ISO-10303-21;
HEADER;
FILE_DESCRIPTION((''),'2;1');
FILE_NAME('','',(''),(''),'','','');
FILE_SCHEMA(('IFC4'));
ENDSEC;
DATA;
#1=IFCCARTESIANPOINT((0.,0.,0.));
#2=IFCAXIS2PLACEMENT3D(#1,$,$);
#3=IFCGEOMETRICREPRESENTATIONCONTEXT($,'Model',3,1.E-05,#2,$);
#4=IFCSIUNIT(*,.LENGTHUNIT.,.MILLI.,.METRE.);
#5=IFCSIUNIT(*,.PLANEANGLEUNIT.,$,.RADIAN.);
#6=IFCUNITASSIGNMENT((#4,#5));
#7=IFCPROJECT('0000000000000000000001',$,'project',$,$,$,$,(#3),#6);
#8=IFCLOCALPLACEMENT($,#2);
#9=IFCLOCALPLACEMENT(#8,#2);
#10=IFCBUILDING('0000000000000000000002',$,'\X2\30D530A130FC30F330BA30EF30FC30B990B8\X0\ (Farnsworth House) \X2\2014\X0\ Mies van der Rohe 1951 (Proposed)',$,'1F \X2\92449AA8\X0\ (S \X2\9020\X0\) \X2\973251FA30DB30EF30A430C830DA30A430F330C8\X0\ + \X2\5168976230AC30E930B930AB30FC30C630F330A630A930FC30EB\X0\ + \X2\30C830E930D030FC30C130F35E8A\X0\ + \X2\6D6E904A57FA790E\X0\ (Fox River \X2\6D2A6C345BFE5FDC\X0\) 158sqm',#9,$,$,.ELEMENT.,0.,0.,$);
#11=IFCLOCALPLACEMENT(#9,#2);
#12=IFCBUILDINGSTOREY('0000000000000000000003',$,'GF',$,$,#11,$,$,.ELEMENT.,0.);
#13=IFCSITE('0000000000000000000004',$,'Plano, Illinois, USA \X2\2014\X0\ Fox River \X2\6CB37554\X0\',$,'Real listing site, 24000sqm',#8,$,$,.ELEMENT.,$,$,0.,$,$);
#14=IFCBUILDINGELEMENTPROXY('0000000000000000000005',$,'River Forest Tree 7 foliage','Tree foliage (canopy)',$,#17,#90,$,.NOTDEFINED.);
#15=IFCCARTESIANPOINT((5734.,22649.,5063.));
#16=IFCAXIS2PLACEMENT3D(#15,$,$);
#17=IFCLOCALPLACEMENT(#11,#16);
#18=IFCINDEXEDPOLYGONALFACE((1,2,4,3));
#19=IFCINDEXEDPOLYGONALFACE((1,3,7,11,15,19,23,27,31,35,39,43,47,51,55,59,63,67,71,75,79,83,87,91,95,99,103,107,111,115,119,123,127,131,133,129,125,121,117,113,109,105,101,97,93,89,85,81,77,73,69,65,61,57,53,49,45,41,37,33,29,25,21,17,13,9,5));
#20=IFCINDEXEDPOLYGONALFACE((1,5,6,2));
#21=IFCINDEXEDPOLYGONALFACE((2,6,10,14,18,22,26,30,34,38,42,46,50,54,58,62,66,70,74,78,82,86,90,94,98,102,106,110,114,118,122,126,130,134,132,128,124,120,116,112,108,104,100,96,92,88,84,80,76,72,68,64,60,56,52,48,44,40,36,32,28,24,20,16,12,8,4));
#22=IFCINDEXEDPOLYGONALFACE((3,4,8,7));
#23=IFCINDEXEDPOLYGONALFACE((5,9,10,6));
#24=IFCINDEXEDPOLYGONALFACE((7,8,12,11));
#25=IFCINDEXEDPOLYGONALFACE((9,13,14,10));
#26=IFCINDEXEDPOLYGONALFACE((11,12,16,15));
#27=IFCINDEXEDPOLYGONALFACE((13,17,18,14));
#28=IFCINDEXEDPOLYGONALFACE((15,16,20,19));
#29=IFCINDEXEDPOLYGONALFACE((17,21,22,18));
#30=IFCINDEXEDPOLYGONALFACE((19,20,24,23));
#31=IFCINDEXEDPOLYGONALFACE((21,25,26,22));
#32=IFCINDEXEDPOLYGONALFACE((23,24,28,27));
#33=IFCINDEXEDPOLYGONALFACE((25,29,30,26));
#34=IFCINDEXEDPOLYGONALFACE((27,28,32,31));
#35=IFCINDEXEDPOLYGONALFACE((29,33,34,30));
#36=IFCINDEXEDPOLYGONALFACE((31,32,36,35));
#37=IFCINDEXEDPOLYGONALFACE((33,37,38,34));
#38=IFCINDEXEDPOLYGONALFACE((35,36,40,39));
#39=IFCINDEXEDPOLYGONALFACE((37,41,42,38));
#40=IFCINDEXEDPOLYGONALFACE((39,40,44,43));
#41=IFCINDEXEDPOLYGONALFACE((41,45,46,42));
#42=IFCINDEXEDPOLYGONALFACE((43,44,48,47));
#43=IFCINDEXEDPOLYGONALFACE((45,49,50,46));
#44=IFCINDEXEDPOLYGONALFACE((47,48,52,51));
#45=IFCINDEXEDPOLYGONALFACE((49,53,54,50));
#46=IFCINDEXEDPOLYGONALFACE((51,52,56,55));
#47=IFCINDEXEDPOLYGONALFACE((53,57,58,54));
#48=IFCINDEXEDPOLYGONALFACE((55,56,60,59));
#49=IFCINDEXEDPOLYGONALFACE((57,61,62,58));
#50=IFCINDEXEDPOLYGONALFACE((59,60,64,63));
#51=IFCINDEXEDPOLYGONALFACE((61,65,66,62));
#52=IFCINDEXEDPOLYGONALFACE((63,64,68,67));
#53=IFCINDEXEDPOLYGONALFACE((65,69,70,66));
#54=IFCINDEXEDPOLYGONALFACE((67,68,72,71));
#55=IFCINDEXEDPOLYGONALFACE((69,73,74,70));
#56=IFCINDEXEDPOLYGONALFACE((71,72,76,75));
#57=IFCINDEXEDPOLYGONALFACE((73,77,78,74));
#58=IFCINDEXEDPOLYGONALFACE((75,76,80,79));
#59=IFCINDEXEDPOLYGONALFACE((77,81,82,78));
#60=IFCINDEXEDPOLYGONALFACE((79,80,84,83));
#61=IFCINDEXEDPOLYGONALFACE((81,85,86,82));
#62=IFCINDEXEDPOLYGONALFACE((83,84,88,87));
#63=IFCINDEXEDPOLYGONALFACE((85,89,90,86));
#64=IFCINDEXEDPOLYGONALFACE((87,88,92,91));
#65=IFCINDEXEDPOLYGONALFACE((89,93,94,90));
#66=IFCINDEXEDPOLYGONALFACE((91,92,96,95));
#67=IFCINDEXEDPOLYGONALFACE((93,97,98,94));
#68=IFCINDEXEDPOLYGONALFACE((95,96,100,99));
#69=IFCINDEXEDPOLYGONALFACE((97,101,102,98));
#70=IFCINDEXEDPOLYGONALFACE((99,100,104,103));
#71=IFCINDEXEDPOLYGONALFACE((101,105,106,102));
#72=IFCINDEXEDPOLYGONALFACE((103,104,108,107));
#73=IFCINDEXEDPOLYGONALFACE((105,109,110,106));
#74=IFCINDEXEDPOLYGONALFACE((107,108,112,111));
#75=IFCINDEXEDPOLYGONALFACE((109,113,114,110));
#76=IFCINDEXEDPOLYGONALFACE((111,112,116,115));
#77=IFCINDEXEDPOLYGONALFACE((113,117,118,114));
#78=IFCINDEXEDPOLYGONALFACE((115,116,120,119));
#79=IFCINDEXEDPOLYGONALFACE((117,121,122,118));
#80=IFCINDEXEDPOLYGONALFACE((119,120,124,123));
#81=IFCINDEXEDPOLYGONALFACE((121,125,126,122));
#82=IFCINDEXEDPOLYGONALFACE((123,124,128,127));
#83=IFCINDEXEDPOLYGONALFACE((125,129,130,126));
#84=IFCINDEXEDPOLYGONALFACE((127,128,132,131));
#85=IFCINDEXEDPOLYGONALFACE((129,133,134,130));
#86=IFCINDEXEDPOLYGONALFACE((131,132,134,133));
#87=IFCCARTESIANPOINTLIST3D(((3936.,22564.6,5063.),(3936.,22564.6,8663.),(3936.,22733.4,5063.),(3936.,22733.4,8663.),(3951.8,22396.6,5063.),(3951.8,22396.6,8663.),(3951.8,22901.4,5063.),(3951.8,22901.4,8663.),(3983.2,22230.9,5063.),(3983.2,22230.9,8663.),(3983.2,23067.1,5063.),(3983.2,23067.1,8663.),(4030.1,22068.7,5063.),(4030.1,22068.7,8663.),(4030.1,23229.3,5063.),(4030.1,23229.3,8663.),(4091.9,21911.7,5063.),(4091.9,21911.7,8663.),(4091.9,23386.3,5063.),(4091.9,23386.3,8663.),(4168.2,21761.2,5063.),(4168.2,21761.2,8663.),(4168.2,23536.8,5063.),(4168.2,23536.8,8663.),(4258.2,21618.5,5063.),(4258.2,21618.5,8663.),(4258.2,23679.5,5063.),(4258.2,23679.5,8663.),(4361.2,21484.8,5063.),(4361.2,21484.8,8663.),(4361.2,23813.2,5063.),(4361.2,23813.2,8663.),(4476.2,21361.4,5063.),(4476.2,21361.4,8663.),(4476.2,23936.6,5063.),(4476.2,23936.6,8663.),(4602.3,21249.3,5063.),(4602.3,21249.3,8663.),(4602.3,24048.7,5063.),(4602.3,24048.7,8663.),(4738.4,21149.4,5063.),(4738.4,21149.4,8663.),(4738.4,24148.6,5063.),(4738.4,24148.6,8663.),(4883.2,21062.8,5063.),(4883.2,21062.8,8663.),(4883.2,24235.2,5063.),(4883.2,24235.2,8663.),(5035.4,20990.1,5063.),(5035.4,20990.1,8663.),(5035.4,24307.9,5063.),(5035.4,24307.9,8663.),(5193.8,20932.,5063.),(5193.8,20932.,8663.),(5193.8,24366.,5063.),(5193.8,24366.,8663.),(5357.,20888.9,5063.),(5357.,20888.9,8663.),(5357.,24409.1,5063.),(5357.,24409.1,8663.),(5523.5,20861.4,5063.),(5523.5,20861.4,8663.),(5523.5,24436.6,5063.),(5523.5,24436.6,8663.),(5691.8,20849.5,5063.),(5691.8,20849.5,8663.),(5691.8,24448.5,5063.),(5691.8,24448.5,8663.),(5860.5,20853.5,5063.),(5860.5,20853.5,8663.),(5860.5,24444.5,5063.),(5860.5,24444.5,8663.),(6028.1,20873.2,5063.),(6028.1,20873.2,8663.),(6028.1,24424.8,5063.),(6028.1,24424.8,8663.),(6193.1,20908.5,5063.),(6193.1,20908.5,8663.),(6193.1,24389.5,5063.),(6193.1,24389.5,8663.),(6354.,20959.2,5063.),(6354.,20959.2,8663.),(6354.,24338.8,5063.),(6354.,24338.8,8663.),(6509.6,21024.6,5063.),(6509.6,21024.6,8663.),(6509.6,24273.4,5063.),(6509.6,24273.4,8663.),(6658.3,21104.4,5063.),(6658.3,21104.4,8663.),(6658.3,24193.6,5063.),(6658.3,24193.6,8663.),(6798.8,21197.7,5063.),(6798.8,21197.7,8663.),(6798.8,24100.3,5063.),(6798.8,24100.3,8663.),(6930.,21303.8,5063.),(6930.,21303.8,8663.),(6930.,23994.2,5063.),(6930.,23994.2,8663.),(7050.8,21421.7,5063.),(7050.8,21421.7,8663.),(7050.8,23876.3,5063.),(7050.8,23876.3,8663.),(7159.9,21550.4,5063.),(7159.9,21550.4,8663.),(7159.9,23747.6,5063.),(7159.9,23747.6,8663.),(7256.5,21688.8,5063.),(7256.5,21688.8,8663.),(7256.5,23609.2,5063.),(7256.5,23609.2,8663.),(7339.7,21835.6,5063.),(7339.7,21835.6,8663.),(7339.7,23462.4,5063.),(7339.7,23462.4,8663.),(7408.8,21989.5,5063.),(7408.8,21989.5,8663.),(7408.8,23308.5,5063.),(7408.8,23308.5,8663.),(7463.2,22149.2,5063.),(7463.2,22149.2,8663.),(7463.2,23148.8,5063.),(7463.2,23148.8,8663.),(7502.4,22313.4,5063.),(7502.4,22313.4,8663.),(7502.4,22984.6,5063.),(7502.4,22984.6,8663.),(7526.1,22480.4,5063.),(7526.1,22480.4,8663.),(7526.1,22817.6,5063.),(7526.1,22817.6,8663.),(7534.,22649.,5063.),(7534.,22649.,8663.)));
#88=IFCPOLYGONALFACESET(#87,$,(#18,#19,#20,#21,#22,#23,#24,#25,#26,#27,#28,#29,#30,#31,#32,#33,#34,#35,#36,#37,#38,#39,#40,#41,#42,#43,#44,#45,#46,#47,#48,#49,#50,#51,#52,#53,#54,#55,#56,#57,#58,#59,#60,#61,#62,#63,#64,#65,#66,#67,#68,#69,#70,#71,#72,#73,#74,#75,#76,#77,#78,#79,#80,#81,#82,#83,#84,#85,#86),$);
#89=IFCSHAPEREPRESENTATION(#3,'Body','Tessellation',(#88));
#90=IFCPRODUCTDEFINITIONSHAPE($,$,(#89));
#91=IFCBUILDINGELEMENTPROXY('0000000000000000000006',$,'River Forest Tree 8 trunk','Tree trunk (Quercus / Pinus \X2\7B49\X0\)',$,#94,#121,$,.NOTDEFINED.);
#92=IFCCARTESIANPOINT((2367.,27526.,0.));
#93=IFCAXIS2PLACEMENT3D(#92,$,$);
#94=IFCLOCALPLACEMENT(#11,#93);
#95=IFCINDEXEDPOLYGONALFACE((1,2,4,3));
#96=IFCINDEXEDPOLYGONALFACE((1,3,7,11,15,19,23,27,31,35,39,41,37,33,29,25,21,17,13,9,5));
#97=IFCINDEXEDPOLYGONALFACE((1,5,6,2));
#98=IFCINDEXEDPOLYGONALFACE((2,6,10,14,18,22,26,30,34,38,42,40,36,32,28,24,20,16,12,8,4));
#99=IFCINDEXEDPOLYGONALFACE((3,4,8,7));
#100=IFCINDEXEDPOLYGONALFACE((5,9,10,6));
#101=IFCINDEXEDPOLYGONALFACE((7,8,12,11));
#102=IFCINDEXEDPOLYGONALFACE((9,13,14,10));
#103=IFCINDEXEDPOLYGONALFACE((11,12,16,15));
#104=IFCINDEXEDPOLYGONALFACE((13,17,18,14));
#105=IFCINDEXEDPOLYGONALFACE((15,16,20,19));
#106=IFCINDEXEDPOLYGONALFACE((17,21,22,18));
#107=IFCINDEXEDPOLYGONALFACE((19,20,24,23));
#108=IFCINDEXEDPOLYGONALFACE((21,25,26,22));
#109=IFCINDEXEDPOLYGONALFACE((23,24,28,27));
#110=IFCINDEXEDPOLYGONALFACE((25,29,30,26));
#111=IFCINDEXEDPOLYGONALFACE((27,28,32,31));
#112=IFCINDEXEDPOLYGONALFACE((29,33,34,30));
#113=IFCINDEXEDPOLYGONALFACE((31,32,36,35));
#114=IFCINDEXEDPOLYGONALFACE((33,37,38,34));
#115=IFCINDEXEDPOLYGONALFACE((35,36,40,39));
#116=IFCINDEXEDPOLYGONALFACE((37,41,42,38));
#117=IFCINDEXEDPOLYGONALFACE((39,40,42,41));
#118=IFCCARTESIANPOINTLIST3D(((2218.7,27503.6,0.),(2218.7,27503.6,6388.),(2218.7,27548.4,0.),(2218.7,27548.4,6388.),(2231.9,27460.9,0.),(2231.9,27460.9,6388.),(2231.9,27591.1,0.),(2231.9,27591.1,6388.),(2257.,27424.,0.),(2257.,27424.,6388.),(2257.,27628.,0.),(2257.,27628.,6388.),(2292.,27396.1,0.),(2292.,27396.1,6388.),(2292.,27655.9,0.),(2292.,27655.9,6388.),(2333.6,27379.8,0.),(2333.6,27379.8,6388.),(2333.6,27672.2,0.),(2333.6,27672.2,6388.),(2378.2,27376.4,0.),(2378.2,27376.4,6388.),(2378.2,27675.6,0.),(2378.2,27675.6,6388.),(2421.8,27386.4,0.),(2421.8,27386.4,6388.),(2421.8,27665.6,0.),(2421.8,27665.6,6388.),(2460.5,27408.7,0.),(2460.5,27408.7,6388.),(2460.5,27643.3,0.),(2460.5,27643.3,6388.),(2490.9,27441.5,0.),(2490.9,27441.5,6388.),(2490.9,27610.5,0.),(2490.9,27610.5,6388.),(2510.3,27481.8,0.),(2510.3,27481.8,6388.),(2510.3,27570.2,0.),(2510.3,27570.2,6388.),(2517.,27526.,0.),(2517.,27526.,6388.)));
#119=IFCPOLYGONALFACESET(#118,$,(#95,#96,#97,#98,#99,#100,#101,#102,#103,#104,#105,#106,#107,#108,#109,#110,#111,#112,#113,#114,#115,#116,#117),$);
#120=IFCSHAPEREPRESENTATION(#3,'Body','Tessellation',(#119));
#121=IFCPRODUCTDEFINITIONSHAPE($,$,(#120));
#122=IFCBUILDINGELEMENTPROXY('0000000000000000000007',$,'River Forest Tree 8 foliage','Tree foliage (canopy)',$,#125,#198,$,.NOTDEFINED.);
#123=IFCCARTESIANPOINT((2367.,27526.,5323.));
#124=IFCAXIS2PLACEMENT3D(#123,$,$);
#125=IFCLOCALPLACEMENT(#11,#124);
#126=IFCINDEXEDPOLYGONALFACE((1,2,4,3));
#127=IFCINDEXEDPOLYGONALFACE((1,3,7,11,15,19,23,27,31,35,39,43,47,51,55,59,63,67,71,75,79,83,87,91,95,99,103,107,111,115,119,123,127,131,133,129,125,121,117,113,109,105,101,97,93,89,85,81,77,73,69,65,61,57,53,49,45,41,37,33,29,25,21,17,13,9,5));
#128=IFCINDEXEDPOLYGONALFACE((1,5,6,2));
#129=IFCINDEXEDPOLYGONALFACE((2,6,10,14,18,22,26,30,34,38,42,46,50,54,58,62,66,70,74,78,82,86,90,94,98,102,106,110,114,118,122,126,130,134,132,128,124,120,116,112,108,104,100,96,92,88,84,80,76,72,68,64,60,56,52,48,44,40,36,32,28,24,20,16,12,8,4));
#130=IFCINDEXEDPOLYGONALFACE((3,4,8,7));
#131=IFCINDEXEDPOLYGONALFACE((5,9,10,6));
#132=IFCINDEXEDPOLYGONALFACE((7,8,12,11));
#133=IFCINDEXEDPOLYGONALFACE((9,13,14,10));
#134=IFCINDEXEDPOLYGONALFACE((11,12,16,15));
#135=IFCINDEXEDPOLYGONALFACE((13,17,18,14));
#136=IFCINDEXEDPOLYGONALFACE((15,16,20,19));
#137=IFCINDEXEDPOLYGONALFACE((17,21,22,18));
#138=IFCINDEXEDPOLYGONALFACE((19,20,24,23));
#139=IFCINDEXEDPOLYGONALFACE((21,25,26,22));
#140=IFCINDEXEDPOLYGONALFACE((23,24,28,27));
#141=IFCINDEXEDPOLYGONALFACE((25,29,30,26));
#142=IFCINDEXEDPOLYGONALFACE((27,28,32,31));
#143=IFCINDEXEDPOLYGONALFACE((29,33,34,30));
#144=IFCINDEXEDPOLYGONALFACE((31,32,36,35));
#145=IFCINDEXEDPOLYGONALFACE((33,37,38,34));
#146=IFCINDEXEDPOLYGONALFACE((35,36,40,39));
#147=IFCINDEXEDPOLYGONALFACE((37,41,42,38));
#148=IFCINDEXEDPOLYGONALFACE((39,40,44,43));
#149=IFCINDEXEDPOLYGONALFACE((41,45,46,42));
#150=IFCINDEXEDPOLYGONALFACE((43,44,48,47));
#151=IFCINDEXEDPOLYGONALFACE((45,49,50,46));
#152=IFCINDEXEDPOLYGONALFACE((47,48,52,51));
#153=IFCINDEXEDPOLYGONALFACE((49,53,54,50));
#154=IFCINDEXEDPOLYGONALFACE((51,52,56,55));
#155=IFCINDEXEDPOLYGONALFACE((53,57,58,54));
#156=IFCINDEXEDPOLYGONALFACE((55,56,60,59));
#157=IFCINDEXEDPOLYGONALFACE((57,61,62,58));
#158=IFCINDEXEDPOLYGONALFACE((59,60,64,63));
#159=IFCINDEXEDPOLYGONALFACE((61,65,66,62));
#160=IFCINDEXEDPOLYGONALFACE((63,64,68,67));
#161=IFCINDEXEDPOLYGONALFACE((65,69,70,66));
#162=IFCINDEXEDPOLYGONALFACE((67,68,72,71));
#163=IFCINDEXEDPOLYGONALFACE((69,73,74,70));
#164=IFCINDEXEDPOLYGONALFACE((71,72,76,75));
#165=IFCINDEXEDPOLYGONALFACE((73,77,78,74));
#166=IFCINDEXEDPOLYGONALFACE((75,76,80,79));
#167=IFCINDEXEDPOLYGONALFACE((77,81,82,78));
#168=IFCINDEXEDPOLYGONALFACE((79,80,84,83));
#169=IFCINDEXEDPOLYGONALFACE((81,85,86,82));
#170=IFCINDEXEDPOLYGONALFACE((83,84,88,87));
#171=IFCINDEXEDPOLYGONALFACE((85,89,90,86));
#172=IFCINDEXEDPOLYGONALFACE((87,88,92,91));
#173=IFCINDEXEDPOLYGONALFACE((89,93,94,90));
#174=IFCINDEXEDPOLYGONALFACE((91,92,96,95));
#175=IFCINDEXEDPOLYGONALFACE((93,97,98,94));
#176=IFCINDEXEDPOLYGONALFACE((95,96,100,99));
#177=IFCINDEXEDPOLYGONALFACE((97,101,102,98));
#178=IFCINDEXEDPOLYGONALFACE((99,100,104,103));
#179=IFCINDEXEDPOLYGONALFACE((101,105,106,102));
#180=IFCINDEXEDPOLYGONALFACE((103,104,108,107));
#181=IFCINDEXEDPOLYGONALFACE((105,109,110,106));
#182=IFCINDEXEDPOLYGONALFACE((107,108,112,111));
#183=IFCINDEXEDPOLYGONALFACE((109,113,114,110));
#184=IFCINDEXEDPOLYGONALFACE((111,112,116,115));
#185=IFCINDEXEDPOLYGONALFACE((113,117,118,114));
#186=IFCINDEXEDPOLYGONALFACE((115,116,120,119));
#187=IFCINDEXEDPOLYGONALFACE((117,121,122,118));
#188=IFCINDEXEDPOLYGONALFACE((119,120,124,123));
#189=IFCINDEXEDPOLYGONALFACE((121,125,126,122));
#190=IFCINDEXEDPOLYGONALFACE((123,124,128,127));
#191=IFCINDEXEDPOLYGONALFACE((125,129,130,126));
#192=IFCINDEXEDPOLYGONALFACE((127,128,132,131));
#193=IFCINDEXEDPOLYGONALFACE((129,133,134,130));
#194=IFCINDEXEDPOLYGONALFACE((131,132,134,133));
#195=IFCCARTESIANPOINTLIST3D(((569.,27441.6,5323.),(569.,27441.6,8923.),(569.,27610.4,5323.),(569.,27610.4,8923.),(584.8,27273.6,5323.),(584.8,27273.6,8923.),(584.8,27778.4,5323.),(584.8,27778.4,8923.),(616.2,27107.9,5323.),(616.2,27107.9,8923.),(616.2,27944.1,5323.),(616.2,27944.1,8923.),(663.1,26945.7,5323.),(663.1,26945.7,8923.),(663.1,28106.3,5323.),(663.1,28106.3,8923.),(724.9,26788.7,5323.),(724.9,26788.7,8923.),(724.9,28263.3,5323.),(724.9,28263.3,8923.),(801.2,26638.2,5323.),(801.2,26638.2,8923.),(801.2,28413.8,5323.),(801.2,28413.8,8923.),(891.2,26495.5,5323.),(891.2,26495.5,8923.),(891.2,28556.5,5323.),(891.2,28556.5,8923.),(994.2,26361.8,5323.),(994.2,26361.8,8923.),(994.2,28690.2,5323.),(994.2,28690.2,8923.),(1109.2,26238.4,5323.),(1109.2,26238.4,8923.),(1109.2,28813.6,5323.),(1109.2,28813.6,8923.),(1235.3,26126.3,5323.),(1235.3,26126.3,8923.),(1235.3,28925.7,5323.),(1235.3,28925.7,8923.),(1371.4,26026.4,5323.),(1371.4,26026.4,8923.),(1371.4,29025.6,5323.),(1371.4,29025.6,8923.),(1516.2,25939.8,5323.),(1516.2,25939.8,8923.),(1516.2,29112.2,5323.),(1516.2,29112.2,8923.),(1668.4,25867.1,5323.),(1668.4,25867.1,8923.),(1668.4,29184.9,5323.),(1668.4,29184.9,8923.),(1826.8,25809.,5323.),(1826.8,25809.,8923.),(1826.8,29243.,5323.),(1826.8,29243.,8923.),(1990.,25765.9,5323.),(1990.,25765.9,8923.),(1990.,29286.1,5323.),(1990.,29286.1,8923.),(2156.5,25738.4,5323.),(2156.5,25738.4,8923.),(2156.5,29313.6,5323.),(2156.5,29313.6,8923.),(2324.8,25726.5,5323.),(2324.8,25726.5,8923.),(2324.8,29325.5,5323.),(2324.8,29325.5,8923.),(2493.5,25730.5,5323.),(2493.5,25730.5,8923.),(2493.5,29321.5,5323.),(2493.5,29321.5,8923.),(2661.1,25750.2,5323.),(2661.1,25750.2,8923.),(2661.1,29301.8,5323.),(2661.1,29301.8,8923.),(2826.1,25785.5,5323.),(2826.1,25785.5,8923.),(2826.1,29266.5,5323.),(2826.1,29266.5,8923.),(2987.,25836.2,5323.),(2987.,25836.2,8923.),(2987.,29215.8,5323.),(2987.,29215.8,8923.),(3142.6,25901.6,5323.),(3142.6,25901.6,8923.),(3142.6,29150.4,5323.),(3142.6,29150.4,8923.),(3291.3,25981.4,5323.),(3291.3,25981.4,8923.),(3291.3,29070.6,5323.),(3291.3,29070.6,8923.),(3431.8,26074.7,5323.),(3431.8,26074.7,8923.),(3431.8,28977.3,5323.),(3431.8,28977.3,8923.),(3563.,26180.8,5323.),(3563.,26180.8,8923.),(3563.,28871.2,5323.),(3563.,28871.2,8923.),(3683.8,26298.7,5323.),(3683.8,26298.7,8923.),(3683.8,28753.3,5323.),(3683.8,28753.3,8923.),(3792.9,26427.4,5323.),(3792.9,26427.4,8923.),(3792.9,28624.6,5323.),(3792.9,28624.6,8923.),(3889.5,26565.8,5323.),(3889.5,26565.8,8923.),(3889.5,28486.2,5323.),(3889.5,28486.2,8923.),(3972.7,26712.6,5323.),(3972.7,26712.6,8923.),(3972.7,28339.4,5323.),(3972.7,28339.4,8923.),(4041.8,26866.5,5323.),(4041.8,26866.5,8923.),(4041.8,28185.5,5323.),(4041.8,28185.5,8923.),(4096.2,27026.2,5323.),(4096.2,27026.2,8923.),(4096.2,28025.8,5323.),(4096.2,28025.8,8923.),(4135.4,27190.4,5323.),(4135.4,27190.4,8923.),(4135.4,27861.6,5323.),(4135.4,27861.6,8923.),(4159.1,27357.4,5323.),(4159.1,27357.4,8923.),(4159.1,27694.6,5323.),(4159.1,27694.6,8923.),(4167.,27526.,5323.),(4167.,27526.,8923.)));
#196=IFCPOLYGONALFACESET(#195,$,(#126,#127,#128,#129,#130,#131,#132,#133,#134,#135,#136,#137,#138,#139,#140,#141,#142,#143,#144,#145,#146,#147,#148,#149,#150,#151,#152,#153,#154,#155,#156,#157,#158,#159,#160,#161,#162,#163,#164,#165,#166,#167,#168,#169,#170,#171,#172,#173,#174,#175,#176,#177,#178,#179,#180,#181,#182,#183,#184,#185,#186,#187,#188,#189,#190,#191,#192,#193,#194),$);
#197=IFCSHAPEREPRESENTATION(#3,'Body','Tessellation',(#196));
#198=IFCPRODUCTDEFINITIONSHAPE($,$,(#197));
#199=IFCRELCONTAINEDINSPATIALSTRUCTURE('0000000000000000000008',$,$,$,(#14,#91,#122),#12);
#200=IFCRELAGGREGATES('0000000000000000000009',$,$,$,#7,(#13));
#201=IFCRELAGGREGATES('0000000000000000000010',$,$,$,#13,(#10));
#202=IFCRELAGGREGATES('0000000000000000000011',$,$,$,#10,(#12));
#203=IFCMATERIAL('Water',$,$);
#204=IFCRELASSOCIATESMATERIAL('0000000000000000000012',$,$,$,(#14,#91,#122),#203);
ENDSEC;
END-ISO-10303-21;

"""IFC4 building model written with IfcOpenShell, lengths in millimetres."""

from ifc_helpers import new_model, si_unit, frame, origin, origin_2d, place, context, project, spatial, circle, extrude, material, element, save


model = new_model("IFC4")

# Units and contexts
model_context = context("Model", 3, precision=1e-05, world=origin())
ifc_project = project(units=[si_unit("LENGTHUNIT", "METRE", prefix="MILLI"), si_unit("PLANEANGLEUNIT", "RADIAN")], contexts=[model_context])

# Site, building, storey
site_placement = place(None, origin())
site = spatial("IfcSite", under=ifc_project, at=site_placement, Name="Plano, Illinois, USA — Fox River 河畔", ObjectType="Real listing site, 24000sqm", CompositionType="ELEMENT", RefElevation=0.0)
building_placement = place(site_placement, origin())
building = spatial("IfcBuilding", under=site, at=building_placement, Name="ファーンズワース邸 (Farnsworth House) — Mies van der Rohe 1951 (Proposed)", ObjectType="1F 鉄骨 (S 造) 露出ホワイトペイント + 全面ガラスカーテンウォール + トラバーチン床 + 浮遊基礎 (Fox River 洪水対応) 158sqm", CompositionType="ELEMENT", ElevationOfRefHeight=0.0, ElevationOfTerrain=0.0)
storey_placement = place(building_placement, origin())
storey = spatial("IfcBuildingStorey", under=building, at=storey_placement, Name="GF", CompositionType="ELEMENT", Elevation=0.0)

# Building element proxies
ifc_material_1 = material(Name="Water")
proxy_1_placement = place(storey_placement, frame((5734.0, 22649.0, 5063.0)))
element("IfcBuildingElementProxy", 1, at=proxy_1_placement, inside=storey, material=ifc_material_1, Name="River Forest Tree 7 foliage", Description="Tree foliage (canopy)", PredefinedType="NOTDEFINED", context=model_context, shape_type="SweptSolid", body=[
    extrude(circle(Radius=1800.0, at=origin_2d()), frame((5734.0, 22649.0, 5063.0)), (0.0, 0.0, 1.0), 3600.0),
])
proxy_2_placement = place(storey_placement, frame((2367.0, 27526.0, 0.0)))
element("IfcBuildingElementProxy", 2, at=proxy_2_placement, inside=storey, material=ifc_material_1, Name="River Forest Tree 8 trunk", Description="Tree trunk (Quercus / Pinus 等)", PredefinedType="NOTDEFINED", context=model_context, shape_type="SweptSolid", body=[
    extrude(circle(Radius=150.0, at=origin_2d()), frame((2367.0, 27526.0, 0.0)), (0.0, 0.0, 1.0), 6388.0),
])
proxy_3_placement = place(storey_placement, frame((2367.0, 27526.0, 5323.0)))
element("IfcBuildingElementProxy", 3, at=proxy_3_placement, inside=storey, material=ifc_material_1, Name="River Forest Tree 8 foliage", Description="Tree foliage (canopy)", PredefinedType="NOTDEFINED", context=model_context, shape_type="SweptSolid", body=[
    extrude(circle(Radius=1800.0, at=origin_2d()), frame((2367.0, 27526.0, 5323.0)), (0.0, 0.0, 1.0), 3600.0),
])

save(model, "model.ifc")
